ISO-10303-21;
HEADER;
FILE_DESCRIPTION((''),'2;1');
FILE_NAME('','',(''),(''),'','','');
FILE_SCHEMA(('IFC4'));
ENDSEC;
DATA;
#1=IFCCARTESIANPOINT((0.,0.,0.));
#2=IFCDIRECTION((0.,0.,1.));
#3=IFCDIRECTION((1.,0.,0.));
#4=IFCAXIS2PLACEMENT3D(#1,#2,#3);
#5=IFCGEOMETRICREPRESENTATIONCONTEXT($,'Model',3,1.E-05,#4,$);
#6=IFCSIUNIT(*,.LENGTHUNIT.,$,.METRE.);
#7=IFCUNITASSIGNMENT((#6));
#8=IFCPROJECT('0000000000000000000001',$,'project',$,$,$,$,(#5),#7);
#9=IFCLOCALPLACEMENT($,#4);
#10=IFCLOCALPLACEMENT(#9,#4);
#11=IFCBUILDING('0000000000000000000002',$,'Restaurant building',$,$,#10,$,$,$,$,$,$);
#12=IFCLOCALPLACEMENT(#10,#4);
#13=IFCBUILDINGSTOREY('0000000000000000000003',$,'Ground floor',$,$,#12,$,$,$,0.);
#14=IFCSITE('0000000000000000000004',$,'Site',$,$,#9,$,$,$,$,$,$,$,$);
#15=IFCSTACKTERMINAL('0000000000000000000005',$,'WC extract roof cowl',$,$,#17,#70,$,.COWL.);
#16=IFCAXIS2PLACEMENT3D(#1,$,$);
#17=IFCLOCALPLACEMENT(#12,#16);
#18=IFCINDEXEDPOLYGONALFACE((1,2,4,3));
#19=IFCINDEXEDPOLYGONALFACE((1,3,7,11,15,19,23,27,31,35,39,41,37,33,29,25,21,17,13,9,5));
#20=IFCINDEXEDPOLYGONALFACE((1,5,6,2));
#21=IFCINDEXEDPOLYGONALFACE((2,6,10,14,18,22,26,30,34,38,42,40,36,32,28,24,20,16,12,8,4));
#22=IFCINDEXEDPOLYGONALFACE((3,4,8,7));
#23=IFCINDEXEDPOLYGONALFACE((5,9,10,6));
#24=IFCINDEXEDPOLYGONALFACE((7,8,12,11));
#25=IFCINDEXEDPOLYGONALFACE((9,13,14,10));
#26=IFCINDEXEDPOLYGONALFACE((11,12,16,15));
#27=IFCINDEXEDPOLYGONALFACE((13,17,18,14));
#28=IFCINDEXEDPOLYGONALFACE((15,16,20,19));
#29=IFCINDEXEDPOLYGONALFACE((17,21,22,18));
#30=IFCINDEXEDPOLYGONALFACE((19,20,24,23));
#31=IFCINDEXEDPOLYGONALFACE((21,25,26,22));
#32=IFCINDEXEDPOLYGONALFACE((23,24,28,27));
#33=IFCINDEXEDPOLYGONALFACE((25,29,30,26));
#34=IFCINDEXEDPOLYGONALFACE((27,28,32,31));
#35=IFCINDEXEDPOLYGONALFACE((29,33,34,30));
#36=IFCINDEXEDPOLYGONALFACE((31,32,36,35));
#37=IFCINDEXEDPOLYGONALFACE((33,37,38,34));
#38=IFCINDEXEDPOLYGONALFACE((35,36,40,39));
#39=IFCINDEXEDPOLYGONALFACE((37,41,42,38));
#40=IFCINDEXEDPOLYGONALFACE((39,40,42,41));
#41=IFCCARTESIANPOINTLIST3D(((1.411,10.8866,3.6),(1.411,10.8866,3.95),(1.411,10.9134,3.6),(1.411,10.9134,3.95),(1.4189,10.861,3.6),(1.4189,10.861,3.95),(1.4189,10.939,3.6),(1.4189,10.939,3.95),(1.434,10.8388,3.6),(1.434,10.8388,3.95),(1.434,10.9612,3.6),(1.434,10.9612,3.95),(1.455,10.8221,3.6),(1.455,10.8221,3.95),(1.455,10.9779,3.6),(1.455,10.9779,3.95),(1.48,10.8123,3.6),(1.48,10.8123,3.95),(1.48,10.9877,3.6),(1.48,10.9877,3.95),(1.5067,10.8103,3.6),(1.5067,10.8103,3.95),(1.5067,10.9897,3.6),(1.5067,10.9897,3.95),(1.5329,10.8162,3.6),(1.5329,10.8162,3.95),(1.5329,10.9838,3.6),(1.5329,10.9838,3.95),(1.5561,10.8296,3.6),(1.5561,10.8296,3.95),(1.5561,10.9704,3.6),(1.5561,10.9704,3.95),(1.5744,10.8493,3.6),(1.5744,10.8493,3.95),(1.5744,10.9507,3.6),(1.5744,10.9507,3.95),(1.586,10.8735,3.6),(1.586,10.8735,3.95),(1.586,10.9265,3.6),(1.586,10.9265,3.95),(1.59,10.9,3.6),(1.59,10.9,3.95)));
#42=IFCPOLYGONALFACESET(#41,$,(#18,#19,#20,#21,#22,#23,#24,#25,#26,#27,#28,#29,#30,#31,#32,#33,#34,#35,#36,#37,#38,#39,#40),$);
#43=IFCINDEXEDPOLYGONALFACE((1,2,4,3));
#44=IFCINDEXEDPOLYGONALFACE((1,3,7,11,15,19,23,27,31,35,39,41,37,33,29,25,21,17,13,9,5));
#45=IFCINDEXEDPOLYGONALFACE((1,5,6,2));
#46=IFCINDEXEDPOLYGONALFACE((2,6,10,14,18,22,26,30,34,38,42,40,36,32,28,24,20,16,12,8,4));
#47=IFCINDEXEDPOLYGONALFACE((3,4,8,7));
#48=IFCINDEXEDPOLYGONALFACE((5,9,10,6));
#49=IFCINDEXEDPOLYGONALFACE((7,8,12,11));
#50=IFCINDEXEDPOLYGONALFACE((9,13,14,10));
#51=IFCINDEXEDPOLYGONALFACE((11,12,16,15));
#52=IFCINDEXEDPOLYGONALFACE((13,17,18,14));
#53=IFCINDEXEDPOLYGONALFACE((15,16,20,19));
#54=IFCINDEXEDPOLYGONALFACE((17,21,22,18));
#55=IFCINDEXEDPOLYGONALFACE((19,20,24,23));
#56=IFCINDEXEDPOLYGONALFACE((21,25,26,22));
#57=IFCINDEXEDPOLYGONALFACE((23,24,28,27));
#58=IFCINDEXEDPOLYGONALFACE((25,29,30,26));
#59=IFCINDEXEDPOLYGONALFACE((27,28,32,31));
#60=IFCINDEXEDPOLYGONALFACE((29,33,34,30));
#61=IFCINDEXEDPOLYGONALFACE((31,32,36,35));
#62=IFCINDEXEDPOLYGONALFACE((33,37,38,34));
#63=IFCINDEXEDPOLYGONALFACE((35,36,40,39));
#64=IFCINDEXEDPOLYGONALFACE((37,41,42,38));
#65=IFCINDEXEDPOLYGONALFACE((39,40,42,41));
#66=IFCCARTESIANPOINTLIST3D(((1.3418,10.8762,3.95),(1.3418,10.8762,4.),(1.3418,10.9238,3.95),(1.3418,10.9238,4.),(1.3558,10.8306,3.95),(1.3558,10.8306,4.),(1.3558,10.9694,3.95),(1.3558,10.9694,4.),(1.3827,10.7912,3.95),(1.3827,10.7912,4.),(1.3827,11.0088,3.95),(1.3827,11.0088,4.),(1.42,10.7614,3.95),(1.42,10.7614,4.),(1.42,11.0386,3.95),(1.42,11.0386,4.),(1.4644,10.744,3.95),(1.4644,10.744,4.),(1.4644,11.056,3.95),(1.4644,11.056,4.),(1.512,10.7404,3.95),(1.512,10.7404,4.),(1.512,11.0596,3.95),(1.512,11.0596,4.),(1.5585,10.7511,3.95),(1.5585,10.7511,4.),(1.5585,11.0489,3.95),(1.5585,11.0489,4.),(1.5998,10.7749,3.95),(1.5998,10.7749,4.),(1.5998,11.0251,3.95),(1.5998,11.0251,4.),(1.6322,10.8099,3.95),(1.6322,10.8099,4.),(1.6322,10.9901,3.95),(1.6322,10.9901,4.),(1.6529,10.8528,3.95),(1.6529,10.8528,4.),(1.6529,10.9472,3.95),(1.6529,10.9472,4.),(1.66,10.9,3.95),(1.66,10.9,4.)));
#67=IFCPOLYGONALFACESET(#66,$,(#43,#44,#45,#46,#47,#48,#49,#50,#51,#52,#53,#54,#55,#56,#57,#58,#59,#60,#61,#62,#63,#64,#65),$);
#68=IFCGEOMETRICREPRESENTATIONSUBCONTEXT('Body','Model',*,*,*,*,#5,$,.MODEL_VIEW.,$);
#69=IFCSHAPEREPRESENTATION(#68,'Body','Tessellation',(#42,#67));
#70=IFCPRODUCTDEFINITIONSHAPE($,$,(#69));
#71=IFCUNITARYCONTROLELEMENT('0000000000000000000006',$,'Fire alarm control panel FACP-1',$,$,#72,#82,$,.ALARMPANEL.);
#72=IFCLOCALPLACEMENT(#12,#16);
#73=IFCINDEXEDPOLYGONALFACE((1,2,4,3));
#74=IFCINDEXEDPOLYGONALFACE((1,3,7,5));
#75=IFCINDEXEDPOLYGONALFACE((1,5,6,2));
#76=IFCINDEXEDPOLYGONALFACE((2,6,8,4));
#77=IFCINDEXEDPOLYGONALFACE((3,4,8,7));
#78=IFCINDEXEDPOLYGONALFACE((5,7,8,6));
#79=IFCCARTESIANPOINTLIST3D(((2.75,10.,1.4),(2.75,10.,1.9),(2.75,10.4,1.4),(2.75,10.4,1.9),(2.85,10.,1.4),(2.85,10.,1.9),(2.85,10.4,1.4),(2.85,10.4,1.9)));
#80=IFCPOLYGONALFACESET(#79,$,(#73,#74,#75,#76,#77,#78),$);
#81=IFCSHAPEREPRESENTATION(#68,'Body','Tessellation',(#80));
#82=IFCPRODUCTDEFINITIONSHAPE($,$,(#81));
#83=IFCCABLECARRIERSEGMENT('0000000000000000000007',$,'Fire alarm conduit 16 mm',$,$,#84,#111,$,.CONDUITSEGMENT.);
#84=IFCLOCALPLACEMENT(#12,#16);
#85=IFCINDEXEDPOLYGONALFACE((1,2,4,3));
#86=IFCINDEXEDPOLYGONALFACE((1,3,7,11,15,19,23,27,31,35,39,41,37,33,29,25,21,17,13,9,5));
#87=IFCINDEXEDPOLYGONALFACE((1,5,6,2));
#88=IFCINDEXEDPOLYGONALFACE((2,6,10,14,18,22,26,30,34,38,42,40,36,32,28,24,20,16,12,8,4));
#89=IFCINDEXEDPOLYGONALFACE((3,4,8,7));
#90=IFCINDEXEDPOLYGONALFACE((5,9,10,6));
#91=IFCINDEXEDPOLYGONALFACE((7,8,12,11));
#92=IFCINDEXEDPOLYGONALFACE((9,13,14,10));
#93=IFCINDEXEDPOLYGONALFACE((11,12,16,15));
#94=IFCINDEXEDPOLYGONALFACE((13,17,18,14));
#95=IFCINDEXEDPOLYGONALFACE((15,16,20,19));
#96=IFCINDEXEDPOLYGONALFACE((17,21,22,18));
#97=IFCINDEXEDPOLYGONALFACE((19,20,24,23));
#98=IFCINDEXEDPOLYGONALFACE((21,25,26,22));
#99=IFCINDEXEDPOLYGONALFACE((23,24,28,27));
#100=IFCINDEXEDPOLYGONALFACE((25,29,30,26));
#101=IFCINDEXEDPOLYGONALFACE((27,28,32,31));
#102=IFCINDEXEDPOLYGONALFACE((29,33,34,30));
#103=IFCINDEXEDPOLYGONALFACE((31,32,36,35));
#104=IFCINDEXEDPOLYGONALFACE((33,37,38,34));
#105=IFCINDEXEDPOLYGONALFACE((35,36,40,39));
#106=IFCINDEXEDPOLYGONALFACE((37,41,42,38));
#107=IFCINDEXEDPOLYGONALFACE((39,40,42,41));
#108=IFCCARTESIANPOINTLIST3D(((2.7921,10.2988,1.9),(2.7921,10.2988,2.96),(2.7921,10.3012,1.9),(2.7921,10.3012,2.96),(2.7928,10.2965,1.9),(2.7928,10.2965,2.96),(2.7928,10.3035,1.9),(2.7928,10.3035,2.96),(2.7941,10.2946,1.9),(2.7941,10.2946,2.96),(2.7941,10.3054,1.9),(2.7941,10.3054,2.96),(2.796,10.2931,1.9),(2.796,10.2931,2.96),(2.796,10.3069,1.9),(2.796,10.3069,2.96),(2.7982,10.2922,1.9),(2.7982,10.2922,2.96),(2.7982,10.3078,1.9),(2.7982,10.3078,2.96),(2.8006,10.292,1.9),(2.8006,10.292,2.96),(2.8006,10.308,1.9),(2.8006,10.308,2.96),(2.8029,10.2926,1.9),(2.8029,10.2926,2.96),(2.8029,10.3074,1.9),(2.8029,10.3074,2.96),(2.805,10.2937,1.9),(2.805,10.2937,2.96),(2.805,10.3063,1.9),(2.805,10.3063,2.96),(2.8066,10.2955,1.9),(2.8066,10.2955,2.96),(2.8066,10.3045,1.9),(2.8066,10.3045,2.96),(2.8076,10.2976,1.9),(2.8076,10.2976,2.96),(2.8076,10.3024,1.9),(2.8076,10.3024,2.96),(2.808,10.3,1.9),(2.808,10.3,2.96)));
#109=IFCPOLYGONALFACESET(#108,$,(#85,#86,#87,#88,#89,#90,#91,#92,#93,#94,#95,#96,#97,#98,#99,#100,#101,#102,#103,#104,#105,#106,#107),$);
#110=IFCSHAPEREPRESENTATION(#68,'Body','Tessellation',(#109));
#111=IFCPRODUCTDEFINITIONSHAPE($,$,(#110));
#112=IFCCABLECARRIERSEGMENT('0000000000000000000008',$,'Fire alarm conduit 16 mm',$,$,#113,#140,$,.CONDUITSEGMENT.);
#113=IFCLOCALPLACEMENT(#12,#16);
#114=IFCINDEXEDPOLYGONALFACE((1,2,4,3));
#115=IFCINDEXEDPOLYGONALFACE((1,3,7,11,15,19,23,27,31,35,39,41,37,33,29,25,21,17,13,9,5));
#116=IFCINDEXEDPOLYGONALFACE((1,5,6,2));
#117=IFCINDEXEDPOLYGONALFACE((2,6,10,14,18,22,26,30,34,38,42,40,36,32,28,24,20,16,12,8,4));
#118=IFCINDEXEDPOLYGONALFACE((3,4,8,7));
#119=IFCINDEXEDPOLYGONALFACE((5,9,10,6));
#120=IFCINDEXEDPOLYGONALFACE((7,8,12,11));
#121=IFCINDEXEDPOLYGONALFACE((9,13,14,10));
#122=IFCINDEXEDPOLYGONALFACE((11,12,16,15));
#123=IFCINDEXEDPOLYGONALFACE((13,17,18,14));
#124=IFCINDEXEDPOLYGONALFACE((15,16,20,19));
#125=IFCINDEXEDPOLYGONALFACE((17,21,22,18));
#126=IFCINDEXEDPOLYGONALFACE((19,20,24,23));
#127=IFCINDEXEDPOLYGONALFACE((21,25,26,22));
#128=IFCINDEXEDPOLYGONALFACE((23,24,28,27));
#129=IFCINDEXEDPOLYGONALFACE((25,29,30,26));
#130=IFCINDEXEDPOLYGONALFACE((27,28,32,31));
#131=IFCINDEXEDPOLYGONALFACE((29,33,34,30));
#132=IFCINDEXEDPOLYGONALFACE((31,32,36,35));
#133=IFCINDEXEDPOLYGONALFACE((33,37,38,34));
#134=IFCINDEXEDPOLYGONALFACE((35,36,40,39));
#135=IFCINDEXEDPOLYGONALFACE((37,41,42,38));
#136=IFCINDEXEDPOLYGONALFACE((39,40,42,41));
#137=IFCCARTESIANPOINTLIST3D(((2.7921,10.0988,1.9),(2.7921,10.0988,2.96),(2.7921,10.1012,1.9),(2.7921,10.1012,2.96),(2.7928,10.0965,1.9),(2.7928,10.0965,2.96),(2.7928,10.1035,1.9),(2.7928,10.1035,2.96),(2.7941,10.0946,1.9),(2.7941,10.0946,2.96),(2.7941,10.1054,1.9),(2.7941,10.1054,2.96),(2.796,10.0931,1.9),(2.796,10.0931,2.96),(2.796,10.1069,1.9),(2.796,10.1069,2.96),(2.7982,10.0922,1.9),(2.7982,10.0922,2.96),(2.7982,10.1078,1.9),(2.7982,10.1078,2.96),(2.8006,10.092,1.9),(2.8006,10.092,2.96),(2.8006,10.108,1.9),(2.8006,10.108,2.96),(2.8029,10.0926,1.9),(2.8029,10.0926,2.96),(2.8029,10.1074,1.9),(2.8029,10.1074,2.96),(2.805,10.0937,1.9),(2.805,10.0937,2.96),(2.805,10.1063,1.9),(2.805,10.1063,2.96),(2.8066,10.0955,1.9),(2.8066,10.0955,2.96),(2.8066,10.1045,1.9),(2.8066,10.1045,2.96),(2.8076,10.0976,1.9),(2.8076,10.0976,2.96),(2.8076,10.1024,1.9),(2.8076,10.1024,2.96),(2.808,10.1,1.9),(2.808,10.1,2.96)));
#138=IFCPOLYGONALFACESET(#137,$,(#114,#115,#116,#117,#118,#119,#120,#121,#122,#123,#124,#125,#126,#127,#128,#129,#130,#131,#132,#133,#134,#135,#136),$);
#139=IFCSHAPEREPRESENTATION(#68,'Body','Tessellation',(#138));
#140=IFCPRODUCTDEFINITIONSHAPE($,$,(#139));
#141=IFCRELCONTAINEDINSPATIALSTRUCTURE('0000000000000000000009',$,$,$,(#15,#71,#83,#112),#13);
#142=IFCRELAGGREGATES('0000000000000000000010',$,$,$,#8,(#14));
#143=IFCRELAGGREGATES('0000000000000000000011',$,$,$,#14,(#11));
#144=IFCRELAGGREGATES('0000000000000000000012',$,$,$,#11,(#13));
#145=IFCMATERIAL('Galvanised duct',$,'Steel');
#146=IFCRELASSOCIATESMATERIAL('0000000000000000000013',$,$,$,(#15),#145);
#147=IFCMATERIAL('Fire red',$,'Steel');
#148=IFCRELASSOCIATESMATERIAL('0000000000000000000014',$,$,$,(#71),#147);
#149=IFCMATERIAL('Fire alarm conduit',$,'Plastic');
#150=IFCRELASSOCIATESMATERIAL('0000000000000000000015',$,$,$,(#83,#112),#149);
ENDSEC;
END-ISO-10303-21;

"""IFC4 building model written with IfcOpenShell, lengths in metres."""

from ifc_helpers import new_model, si_unit, frame, origin, origin_with_axes, origin_2d, place, context, subcontext, project, spatial, rectangle, circle, extrude, material, element, save


model = new_model("IFC4")

# Units and contexts
model_context = context("Model", 3, precision=1e-05, world=origin_with_axes())
body_context = subcontext(model_context, "Body", "Model", "MODEL_VIEW")
ifc_project = project(units=[si_unit("LENGTHUNIT", "METRE")], contexts=[model_context])

# Site, building, storey
site_placement = place(None, origin_with_axes())
site = spatial("IfcSite", under=ifc_project, at=site_placement, Name="Site")
building_placement = place(site_placement, origin_with_axes())
building = spatial("IfcBuilding", under=site, at=building_placement, Name="Restaurant building")
storey_placement = place(building_placement, origin_with_axes())
storey = spatial("IfcBuildingStorey", under=building, at=storey_placement, Name="Ground floor", Elevation=0.0)

# Stack terminal
ifc_material_1 = material(Name="Galvanised duct", Category="Steel")
stack_terminal_1_placement = place(storey_placement, frame((1.5, 10.9, 0.0)))
element("IfcStackTerminal", 1, at=stack_terminal_1_placement, inside=storey, material=ifc_material_1, Name="WC extract roof cowl", PredefinedType="COWL", context=body_context, shape_type="SweptSolid", body=[
    extrude(circle(Radius=0.09, at=origin_2d()), frame((0.0, 0.0, 3.6)), (0.0, 0.0, 1.0), 0.35),
    extrude(circle(Radius=0.16, at=origin_2d()), frame((0.0, 0.0, 3.95)), (0.0, 0.0, 1.0), 0.05),
])

# Unitary control element
ifc_material_2 = material(Name="Fire red", Category="Steel")
unitary_control_element_placement = place(storey_placement, frame((2.8, 10.2, 0.0)))
element("IfcUnitaryControlElement", 2, at=unitary_control_element_placement, inside=storey, material=ifc_material_2, Name="Fire alarm control panel FACP-1", PredefinedType="ALARMPANEL", context=body_context, shape_type="SweptSolid", body=[
    extrude(rectangle(XDim=0.1, YDim=0.4, at=origin_2d()), frame((0.0, 0.0, 1.4)), (0.0, 0.0, 1.0), 0.5),
])

# Cable carrier segments
ifc_material_3 = material(Name="Fire alarm conduit", Category="Plastic")
for number, where, name in (
    (3, (2.8, 10.3, 1.9), "Fire alarm conduit 16 mm"),
    (4, (2.8, 10.1, 1.9), "Fire alarm conduit 16 mm"),
):
    element("IfcCableCarrierSegment", number, at=place(storey_placement, frame(where)), inside=storey, material=ifc_material_3, Name=name, PredefinedType="CONDUITSEGMENT", context=body_context, shape_type="SweptSolid", body=[
        extrude(circle(Radius=0.008, at=origin_2d()), origin(), (0.0, 0.0, 1.0), 1.06),
    ])

save(model, "model.ifc")
